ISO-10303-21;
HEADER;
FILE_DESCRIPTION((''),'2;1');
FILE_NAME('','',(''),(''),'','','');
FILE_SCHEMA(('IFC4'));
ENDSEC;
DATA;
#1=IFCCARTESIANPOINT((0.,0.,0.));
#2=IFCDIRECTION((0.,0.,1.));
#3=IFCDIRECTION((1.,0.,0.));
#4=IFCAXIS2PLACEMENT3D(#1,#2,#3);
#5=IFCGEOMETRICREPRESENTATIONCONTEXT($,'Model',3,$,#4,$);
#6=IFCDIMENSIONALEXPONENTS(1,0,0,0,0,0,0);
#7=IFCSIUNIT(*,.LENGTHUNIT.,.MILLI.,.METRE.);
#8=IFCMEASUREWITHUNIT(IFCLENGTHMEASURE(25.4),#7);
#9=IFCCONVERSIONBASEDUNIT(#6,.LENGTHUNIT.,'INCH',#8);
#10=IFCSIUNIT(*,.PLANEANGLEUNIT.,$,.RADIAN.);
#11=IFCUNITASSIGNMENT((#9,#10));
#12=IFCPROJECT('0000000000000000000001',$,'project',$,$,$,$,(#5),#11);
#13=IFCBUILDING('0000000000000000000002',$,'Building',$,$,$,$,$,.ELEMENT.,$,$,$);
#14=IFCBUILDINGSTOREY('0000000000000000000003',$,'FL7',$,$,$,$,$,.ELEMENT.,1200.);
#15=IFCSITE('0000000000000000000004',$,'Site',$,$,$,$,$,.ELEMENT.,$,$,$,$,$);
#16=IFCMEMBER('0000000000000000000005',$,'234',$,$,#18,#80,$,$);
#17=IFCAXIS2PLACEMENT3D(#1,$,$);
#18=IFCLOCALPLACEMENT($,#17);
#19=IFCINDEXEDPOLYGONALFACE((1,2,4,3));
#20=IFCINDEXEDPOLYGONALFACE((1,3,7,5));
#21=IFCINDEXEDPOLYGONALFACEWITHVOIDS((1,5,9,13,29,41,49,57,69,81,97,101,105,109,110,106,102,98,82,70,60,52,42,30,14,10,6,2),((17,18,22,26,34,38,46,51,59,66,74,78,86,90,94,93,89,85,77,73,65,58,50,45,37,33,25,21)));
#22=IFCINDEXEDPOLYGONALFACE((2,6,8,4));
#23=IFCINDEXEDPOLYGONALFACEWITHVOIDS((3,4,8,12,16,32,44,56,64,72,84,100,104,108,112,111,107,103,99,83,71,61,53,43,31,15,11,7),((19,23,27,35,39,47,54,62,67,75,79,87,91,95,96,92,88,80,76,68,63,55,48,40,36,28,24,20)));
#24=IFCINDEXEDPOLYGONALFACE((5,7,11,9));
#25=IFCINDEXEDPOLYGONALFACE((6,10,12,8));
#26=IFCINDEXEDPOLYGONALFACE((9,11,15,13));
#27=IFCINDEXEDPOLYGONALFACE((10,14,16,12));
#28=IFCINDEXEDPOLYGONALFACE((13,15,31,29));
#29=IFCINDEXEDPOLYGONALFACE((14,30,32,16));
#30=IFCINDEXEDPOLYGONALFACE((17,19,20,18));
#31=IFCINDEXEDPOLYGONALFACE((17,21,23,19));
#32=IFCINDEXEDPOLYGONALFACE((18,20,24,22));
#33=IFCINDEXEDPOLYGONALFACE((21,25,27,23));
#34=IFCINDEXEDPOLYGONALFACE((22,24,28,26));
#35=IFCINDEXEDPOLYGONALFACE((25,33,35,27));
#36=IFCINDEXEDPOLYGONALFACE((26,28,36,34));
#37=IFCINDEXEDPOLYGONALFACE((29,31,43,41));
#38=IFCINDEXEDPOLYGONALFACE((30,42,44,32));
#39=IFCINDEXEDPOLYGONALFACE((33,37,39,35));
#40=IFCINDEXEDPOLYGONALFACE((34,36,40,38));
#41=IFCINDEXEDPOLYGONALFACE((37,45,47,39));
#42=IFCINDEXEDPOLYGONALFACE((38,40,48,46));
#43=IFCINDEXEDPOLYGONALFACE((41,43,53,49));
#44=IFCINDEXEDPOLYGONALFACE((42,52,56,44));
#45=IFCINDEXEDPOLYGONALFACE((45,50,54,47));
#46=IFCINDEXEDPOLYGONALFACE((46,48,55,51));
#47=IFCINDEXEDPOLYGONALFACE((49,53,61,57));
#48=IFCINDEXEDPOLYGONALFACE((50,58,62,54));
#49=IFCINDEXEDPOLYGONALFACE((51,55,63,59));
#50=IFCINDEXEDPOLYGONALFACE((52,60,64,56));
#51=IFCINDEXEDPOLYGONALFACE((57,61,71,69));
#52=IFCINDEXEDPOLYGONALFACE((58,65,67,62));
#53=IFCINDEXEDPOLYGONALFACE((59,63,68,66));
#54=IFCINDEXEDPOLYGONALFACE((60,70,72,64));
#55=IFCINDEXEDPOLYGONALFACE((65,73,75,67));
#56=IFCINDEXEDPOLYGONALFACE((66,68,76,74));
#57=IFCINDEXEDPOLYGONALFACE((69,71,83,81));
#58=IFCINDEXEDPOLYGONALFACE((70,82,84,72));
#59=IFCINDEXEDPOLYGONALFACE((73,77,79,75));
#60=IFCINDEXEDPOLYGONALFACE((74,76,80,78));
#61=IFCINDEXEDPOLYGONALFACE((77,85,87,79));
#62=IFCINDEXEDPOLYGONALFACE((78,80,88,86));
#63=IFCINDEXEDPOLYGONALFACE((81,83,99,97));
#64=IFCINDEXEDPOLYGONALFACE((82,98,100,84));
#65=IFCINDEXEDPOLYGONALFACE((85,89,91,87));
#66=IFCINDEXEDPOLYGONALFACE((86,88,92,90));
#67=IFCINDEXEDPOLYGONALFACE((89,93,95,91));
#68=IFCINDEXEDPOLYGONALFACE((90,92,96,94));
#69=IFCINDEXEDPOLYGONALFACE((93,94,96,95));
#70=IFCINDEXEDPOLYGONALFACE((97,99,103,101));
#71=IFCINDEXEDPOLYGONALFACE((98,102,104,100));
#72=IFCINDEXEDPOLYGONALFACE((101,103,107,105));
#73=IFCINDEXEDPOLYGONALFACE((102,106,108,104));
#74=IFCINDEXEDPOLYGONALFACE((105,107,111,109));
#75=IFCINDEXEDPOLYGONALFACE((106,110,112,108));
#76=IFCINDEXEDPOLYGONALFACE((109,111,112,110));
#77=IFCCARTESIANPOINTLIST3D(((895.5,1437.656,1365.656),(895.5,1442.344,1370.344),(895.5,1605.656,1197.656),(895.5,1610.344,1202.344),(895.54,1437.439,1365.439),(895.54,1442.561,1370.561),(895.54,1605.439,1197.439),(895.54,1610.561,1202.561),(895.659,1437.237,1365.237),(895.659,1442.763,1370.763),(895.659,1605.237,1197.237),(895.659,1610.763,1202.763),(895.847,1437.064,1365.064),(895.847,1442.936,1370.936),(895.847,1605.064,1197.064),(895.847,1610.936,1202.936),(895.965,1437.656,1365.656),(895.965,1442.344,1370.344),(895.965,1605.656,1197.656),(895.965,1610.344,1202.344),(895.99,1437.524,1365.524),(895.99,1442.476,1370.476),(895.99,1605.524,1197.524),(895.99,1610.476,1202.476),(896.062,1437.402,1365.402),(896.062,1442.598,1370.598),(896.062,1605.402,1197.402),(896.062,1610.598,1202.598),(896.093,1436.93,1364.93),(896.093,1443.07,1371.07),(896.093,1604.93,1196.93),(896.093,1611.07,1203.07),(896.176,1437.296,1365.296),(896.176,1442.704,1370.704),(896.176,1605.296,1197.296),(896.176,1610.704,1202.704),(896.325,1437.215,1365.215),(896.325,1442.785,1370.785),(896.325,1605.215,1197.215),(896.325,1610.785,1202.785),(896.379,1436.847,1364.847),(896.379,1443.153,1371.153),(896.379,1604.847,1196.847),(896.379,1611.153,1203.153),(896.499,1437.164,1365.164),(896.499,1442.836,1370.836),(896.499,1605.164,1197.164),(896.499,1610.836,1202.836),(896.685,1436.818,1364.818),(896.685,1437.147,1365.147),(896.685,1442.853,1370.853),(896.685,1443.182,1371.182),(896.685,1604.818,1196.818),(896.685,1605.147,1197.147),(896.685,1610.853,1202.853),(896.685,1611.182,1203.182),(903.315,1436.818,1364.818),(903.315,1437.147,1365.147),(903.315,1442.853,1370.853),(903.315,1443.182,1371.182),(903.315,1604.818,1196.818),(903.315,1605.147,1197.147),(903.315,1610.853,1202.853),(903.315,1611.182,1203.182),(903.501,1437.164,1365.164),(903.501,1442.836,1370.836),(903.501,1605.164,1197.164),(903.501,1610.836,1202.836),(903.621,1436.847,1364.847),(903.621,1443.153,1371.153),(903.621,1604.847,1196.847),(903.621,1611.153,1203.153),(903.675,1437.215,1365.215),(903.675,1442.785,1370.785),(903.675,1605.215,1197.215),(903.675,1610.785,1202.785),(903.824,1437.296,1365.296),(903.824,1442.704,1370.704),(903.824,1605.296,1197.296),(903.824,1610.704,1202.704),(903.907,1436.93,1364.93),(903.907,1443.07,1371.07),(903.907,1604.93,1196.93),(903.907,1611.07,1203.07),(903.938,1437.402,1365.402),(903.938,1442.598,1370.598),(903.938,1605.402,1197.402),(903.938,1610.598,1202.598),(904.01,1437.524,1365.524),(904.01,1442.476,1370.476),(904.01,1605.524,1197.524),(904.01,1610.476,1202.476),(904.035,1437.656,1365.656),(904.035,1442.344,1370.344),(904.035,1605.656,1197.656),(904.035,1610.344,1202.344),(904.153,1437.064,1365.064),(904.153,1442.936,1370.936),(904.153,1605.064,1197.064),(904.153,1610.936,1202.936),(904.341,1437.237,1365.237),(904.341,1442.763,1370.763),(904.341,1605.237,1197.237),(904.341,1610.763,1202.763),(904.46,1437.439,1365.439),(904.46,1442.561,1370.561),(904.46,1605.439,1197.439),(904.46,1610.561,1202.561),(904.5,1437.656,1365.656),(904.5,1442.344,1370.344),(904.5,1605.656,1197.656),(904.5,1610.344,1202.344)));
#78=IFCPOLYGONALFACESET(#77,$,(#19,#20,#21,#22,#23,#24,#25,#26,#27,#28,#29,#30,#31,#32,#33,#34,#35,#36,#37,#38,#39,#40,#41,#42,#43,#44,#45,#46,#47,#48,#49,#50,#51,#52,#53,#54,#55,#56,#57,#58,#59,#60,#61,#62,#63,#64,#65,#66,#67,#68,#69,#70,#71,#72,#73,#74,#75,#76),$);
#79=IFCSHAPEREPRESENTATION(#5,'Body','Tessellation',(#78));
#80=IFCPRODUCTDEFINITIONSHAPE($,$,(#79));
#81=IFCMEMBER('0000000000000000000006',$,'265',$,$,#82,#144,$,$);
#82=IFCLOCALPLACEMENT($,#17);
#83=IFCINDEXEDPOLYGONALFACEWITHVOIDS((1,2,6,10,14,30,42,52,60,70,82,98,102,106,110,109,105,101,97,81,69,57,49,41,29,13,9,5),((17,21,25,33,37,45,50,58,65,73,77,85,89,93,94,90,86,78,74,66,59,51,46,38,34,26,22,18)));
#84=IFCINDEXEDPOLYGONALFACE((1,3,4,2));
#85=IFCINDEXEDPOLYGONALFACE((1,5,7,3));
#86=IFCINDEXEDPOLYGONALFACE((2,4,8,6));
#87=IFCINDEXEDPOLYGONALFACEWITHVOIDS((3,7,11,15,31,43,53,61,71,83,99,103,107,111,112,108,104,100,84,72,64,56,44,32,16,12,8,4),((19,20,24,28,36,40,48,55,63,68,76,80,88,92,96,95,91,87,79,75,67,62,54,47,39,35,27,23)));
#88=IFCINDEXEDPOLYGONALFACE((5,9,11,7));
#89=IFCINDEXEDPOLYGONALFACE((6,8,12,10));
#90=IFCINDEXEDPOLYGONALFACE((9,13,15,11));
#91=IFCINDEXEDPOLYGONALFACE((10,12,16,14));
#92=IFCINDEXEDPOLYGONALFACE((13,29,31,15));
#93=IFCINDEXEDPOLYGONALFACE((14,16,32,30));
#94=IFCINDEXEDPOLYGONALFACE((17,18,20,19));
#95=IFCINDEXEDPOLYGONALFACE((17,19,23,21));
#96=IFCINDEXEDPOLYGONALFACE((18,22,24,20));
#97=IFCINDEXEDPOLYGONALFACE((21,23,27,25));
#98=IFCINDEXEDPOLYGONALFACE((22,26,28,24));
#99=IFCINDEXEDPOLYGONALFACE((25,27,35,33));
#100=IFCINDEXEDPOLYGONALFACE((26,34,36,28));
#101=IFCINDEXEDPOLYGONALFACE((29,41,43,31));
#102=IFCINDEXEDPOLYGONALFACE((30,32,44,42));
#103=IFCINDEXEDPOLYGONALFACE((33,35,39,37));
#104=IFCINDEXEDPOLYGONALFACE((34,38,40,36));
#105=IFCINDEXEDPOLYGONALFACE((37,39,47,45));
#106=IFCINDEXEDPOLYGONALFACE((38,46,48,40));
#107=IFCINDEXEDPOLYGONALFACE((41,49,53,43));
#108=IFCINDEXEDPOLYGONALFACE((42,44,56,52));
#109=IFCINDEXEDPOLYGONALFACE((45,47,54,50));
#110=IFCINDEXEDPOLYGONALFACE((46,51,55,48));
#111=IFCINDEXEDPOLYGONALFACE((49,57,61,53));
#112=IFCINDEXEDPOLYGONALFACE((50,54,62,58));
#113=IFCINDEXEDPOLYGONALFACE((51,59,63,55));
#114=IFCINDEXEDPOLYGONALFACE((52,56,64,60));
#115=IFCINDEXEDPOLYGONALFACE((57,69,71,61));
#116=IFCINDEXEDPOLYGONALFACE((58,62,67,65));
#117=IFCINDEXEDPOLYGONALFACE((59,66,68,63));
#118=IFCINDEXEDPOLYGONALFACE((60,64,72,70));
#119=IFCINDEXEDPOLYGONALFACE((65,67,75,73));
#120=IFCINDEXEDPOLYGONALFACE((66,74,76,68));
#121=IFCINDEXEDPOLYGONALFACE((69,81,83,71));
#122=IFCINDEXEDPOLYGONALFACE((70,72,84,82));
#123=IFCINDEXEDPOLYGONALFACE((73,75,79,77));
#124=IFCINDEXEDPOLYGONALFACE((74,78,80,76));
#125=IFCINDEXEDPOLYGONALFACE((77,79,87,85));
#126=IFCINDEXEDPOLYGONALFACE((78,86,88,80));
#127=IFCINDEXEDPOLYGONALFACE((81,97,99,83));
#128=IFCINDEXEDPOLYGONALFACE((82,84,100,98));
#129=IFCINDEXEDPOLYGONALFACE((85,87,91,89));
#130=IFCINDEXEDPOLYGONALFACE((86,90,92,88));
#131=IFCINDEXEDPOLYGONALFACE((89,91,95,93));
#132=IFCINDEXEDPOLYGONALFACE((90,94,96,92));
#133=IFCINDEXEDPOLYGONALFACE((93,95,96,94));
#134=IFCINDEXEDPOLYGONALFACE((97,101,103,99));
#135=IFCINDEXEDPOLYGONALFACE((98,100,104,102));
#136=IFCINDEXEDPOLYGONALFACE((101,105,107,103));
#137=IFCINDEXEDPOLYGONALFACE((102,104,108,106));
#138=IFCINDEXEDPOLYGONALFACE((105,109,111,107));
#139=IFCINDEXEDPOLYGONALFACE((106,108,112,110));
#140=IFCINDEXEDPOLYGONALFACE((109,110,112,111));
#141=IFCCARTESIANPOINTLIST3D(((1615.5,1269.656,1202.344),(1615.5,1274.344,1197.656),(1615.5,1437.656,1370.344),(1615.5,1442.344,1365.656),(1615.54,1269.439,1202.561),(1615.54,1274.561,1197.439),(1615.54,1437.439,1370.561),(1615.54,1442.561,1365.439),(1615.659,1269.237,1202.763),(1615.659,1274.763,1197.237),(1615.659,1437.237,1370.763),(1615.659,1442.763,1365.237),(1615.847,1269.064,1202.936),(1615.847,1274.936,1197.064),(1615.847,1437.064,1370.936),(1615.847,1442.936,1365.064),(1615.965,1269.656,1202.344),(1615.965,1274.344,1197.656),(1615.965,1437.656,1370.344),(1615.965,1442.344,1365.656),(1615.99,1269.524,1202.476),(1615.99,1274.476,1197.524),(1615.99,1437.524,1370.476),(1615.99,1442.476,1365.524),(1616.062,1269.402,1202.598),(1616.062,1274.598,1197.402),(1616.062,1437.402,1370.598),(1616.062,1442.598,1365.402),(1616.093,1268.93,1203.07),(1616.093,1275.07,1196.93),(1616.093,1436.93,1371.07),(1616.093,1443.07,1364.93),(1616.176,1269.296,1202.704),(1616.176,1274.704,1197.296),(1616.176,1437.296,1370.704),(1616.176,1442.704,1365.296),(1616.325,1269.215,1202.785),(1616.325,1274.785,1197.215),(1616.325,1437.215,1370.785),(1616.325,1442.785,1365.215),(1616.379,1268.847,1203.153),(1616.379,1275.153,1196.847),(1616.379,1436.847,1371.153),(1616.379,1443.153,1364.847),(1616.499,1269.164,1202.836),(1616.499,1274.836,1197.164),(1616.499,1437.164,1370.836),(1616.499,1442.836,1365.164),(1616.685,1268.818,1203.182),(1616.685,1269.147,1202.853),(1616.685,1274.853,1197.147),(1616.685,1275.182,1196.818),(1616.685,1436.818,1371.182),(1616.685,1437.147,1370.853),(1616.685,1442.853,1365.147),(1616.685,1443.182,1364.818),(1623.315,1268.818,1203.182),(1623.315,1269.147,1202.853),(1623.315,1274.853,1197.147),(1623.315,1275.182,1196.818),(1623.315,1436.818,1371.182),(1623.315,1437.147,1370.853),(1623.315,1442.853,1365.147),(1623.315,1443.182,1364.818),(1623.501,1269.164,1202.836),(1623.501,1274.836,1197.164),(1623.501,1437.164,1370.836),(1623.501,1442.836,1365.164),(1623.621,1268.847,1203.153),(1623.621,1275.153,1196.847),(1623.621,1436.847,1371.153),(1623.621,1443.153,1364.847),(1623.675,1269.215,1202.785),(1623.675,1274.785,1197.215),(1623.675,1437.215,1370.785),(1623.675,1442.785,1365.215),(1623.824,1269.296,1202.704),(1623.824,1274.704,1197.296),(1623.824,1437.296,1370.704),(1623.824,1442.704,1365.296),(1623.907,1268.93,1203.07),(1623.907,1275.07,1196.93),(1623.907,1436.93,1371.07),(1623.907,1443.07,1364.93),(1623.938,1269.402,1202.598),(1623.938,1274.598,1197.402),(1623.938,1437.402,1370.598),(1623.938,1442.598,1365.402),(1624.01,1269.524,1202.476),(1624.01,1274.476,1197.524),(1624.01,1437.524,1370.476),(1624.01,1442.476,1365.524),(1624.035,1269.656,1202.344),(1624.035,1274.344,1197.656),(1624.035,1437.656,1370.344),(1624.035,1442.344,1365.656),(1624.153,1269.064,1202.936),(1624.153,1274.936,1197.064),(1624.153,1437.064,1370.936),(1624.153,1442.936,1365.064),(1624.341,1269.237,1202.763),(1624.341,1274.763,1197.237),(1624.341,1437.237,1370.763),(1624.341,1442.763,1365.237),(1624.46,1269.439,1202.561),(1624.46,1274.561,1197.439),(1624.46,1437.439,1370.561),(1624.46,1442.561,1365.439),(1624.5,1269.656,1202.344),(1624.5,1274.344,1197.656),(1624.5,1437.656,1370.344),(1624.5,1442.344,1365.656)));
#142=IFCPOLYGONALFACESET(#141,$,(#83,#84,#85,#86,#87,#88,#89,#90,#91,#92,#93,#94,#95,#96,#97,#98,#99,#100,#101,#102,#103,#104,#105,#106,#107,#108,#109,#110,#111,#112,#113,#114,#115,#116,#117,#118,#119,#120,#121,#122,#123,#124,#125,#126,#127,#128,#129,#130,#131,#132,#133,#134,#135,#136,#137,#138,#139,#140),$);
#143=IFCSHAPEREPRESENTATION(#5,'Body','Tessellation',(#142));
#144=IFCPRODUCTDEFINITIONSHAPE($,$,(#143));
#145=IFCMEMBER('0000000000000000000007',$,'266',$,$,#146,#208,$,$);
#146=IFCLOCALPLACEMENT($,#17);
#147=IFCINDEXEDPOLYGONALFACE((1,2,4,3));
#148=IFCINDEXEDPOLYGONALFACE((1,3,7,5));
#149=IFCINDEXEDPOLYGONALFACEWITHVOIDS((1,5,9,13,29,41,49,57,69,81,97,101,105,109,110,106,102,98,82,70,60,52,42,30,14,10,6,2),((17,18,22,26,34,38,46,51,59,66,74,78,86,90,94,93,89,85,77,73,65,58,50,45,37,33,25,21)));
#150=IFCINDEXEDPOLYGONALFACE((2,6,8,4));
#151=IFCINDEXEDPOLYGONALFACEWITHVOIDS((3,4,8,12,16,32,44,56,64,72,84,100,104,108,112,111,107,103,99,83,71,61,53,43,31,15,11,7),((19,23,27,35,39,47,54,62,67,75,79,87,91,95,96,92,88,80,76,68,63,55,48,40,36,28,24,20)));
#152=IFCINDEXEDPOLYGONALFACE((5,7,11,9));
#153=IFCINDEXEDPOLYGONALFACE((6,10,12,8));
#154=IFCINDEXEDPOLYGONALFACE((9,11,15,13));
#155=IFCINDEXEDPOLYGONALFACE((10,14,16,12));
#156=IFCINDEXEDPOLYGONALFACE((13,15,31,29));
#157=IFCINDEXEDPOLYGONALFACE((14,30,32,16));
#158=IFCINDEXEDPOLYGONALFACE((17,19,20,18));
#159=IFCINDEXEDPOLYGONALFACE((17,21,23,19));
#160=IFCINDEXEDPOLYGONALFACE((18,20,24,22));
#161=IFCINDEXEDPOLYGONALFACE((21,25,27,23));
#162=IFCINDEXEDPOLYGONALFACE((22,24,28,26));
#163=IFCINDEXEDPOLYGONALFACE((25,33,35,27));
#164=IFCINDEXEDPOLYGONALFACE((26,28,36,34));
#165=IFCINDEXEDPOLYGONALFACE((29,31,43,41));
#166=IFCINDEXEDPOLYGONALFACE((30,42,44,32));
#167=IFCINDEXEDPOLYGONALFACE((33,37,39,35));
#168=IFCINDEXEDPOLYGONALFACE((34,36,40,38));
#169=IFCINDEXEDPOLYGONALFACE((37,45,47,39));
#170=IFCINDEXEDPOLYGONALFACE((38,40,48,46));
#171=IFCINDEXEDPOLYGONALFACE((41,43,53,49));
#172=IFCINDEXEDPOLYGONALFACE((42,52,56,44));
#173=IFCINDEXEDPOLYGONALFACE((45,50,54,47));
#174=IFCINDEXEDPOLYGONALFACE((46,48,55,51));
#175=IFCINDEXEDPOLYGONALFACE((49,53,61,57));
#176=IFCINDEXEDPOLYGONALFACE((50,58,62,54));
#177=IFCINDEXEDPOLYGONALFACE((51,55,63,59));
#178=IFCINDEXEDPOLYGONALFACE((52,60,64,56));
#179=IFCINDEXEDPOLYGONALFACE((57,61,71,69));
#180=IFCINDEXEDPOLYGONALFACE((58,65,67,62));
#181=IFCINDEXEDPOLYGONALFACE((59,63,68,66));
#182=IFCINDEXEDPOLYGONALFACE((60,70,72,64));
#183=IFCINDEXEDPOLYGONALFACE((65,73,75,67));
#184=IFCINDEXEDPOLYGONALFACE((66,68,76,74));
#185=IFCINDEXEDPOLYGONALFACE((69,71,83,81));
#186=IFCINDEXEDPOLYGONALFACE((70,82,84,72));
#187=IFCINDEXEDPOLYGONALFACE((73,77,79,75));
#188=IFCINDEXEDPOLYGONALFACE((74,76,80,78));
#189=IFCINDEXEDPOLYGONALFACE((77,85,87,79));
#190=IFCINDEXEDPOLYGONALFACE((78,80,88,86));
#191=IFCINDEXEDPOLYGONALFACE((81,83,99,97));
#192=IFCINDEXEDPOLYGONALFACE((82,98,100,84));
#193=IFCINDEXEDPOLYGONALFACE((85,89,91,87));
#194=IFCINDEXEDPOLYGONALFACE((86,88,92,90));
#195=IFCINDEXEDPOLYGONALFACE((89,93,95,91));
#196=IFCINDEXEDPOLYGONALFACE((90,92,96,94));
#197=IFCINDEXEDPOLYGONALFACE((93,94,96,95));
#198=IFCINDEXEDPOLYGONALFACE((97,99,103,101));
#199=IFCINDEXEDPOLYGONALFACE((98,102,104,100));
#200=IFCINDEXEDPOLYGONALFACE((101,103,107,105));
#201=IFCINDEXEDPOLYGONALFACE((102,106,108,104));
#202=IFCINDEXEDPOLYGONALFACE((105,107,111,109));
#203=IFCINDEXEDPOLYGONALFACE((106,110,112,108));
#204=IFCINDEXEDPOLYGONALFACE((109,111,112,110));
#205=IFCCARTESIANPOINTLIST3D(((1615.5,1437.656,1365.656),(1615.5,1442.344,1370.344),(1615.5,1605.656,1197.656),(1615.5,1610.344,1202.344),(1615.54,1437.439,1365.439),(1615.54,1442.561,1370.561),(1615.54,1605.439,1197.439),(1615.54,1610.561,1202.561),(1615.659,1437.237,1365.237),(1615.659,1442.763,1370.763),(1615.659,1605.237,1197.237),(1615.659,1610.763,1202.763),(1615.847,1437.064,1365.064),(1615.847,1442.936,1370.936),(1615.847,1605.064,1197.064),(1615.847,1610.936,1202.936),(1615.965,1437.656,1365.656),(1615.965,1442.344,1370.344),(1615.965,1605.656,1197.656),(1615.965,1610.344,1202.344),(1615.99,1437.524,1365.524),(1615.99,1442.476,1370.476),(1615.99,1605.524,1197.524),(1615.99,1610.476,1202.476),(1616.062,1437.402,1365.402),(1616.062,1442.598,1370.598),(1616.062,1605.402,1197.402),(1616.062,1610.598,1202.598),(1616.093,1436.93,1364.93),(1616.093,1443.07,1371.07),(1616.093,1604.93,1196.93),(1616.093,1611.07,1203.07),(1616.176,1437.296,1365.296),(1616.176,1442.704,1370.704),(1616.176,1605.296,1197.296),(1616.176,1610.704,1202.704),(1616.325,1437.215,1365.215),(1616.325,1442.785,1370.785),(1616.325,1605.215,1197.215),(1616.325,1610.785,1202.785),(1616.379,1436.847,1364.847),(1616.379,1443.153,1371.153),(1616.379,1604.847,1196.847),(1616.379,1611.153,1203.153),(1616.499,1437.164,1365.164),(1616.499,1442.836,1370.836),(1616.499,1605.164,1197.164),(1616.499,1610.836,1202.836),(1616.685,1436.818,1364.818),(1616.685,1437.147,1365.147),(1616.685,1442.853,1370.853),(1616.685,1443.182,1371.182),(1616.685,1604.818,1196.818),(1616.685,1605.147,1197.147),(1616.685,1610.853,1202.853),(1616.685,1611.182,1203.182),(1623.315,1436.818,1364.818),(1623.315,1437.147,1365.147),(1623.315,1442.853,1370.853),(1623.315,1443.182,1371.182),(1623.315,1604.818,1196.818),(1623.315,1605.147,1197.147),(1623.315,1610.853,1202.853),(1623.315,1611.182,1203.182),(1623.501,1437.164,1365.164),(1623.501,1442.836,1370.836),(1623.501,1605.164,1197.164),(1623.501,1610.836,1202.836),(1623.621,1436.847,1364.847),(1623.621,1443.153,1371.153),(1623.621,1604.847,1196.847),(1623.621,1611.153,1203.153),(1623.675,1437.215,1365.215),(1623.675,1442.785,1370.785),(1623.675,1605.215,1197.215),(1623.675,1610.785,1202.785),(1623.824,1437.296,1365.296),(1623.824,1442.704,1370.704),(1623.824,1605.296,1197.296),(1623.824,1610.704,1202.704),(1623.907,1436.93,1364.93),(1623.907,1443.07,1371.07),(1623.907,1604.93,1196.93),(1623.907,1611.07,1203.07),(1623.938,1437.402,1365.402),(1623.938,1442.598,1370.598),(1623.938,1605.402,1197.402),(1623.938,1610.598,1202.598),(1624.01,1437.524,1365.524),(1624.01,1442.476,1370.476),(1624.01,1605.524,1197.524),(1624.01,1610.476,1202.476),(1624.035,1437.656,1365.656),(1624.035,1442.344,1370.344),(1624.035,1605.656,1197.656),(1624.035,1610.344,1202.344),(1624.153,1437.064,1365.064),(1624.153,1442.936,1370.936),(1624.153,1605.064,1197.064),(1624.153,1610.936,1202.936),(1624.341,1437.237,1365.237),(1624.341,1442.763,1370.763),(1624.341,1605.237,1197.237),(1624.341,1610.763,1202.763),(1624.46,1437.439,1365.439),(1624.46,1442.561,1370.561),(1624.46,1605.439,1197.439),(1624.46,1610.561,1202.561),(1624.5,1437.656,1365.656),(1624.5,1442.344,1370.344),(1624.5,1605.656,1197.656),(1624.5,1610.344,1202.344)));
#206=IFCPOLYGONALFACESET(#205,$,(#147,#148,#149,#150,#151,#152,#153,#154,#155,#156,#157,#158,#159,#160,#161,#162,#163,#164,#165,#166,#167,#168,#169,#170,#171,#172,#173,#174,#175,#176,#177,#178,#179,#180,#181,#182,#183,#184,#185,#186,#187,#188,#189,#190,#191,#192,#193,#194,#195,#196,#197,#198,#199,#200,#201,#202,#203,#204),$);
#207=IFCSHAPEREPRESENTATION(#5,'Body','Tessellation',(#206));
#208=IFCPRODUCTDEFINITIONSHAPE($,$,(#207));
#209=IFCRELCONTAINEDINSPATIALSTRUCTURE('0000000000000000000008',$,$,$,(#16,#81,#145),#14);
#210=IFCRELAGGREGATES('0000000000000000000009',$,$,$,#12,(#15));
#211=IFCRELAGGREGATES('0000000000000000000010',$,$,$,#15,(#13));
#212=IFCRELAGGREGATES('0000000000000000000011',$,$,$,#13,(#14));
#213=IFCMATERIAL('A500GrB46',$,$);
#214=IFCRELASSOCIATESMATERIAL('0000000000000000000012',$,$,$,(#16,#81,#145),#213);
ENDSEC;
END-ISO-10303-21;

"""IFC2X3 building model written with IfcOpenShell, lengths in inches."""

from ifc_helpers import new_model, entity, si_unit, converted_unit, frame, origin_with_axes, origin_2d_with_axis, place, context, project, spatial, hollow_rectangle, extrude, material, element, save


model = new_model("IFC2X3")

# Units and contexts
model_context = context("Model", 3, world=origin_with_axes())
ifc_project = project(units=[converted_unit("LENGTHUNIT", "INCH", entity("IfcLengthMeasure", 25.4), si_unit("LENGTHUNIT", "METRE", prefix="MILLI"), dimensions=[1, 0, 0, 0, 0, 0, 0]), si_unit("PLANEANGLEUNIT", "RADIAN")], contexts=[model_context])

# Site, building, storey
site = spatial("IfcSite", under=ifc_project, Name="Site", CompositionType="ELEMENT")
building = spatial("IfcBuilding", under=site, Name="Building", CompositionType="ELEMENT")
storey = spatial("IfcBuildingStorey", under=building, Name="FL7", CompositionType="ELEMENT", Elevation=1200.0)

# Members
ifc_material_1 = material(Name="A500GrB46")
for number, where, z_axis, x_axis, name in (
    (1, (900.0, 1608.0, 1200.0), (0.0, -0.707107, 0.707107), (1.0, 0.0, 0.0), "234"),
    (2, (1620.0, 1272.0, 1200.0), (0.0, 0.707107, 0.707107), (-1.0, 0.0, 0.0), "265"),
    (3, (1620.0, 1608.0, 1200.0), (0.0, -0.707107, 0.707107), (1.0, 0.0, 0.0), "266"),
):
    element("IfcMember", number, at=place(None, frame(where, z_axis=z_axis, x_axis=x_axis)), inside=storey, material=ifc_material_1, Name=name, context=model_context, shape_type="SweptSolid", body=[
        extrude(hollow_rectangle(XDim=9.0, YDim=9.0, WallThickness=0.465, InnerFilletRadius=0.72, OuterFilletRadius=1.185, at=origin_2d_with_axis()), origin_with_axes(), (0.0, 0.0, 1.0), 237.588),
    ])

save(model, "model.ifc")
